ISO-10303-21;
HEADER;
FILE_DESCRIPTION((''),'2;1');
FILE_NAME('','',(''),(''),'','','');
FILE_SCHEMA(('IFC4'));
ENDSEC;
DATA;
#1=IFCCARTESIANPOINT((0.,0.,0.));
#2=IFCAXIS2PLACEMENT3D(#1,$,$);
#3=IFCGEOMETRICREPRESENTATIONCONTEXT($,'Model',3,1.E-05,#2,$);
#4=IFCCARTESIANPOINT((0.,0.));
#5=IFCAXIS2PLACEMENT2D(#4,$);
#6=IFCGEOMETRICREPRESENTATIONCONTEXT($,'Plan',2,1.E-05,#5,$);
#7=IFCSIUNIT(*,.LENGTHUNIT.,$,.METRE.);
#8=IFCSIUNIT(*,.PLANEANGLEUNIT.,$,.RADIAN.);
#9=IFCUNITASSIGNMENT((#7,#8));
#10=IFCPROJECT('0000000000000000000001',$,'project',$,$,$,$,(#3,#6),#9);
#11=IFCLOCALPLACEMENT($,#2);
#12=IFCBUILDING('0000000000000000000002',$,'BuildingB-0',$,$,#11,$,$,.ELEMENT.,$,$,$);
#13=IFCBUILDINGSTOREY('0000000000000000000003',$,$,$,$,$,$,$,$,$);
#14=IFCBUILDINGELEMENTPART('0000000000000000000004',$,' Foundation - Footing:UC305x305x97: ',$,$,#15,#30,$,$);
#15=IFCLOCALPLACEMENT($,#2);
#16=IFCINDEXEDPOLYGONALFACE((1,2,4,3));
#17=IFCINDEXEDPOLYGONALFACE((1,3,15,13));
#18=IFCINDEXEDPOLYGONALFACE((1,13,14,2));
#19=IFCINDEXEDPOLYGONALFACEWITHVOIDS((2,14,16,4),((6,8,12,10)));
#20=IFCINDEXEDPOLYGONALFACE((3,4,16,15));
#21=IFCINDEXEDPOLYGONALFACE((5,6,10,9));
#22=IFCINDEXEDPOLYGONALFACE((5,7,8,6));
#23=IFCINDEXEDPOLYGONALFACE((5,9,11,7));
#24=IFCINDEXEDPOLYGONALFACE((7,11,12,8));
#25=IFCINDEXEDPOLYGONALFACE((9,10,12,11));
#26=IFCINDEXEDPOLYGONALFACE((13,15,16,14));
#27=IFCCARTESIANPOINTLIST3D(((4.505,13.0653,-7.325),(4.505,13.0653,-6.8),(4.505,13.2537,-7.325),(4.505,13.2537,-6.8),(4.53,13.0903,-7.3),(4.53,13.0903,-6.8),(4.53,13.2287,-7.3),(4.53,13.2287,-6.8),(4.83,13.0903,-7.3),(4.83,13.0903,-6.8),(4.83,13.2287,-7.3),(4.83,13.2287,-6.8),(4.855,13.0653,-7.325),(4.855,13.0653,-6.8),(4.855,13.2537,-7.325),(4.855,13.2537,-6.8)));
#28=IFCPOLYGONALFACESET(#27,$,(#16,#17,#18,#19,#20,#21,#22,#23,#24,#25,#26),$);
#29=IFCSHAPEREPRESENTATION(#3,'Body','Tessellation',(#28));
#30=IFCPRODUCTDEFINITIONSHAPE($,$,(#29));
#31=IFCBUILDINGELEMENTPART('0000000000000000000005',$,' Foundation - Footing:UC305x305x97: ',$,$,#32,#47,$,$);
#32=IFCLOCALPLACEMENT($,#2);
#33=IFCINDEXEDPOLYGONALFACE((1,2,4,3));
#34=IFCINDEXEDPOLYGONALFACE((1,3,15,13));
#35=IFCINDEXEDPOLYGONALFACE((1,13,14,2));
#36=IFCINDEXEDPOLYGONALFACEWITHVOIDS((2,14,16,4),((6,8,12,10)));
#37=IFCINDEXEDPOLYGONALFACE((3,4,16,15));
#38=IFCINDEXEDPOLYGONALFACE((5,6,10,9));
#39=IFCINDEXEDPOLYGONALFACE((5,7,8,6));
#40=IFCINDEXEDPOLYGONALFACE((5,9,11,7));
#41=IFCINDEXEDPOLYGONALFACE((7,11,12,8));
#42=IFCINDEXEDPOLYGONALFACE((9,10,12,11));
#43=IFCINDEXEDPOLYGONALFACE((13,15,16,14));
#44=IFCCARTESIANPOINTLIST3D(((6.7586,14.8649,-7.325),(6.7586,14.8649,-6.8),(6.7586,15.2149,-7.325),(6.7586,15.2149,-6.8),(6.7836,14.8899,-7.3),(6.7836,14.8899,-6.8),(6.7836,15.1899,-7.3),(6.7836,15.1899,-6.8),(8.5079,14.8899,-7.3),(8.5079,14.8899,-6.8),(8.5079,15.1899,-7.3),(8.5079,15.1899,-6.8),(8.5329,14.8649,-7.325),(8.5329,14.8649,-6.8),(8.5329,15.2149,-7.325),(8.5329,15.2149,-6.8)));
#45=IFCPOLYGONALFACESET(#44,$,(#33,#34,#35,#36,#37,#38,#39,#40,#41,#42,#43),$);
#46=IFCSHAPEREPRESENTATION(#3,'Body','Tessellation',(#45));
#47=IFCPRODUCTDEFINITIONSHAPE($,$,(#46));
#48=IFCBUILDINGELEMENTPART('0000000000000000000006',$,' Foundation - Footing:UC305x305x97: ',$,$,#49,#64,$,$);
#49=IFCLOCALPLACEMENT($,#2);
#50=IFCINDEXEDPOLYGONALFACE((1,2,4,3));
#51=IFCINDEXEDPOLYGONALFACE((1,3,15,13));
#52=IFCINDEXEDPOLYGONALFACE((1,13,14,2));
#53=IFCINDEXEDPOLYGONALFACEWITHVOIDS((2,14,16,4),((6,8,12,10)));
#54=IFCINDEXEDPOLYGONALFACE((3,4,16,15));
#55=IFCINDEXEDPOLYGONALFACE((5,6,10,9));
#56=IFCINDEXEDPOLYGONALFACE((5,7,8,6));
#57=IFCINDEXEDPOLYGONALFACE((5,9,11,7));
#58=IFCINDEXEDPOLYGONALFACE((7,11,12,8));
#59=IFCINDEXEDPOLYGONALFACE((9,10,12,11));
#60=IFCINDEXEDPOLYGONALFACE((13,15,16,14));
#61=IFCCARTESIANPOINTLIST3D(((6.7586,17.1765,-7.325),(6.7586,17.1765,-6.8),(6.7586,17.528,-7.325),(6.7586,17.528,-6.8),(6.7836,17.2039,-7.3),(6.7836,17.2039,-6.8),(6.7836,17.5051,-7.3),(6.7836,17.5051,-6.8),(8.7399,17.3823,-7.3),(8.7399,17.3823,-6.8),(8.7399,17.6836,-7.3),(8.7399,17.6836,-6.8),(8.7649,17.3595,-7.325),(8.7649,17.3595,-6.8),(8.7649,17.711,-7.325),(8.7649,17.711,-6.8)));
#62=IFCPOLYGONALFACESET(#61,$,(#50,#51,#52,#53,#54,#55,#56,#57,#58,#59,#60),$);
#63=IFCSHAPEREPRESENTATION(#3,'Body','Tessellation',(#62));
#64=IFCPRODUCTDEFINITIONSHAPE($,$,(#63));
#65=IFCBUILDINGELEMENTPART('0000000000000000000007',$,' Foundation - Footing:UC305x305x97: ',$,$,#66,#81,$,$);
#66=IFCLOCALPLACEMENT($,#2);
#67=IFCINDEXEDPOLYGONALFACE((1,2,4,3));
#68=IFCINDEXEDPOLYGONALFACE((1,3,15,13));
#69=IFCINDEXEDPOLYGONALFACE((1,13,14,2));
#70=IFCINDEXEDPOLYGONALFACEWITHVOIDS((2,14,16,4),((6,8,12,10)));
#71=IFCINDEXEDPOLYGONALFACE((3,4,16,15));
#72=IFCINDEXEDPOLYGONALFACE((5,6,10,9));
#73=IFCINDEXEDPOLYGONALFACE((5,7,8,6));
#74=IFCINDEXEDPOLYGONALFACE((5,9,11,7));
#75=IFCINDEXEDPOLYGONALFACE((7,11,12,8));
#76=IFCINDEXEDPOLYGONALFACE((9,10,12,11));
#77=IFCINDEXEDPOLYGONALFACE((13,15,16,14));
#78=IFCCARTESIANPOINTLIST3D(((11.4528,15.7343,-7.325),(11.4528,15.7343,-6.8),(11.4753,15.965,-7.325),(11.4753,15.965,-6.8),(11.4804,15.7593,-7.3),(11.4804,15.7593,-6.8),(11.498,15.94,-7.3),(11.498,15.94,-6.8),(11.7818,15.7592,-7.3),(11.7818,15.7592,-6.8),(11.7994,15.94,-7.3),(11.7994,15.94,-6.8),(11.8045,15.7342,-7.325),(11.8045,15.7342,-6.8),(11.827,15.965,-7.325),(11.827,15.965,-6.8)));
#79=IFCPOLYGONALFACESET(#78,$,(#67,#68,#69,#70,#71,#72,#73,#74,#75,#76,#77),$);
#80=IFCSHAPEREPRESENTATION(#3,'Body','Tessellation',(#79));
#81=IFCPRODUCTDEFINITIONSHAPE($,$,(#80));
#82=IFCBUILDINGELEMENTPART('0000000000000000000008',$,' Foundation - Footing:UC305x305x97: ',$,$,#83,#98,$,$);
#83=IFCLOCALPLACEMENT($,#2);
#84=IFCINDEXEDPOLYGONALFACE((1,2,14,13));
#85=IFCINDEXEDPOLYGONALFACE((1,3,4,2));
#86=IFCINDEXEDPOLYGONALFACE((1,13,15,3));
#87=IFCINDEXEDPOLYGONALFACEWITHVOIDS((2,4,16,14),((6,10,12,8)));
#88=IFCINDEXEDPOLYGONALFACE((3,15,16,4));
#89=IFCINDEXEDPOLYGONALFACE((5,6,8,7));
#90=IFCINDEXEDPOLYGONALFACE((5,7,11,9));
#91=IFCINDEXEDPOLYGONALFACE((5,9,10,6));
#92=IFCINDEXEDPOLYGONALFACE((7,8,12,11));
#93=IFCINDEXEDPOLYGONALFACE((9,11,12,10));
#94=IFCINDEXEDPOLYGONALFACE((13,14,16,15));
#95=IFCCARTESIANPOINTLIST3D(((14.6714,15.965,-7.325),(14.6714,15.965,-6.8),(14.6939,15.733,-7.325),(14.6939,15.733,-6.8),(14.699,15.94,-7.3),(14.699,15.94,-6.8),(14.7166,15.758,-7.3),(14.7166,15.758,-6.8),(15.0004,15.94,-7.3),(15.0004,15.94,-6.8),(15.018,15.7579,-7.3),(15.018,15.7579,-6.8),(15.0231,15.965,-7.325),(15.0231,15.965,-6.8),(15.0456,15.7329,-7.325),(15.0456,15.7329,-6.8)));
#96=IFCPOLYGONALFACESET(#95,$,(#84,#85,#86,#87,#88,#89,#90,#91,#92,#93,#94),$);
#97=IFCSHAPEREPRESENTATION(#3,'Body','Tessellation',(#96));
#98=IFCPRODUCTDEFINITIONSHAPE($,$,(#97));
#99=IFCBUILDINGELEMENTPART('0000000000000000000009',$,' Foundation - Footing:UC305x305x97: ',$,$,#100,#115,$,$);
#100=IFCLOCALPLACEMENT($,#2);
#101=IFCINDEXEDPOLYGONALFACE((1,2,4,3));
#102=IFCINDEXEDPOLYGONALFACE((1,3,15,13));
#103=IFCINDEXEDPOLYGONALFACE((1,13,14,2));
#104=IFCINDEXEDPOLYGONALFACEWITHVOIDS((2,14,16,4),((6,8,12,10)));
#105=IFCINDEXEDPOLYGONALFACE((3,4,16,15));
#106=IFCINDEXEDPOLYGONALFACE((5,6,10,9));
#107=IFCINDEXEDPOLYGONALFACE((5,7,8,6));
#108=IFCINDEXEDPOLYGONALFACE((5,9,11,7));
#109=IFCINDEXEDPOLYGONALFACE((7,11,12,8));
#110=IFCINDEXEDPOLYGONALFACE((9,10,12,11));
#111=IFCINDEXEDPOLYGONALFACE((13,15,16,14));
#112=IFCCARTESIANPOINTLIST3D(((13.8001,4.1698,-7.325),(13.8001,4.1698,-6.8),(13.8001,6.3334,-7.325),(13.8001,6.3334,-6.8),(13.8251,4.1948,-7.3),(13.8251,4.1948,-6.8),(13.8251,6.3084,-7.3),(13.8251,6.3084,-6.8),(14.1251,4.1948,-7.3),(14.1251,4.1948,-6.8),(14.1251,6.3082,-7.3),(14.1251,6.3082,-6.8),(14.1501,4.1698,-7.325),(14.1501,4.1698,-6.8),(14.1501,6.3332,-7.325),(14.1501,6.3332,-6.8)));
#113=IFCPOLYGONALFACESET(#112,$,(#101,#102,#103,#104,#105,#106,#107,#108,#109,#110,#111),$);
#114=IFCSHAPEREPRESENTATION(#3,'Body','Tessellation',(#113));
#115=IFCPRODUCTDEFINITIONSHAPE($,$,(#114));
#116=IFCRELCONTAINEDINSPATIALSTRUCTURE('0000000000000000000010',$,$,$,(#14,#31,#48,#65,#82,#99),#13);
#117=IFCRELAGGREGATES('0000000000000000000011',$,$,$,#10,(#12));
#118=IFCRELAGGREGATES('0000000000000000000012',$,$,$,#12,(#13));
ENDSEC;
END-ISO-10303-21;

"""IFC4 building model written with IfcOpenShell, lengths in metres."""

from ifc_helpers import new_model, si_unit, origin, origin_2d, place, context, project, spatial, polyline, outline, extrude, element, save


model = new_model("IFC4")

# Units and contexts
model_context = context("Model", 3, precision=1e-05, world=origin())
plan_context = context("Plan", 2, precision=1e-05, world=origin_2d())
ifc_project = project(units=[si_unit("LENGTHUNIT", "METRE"), si_unit("PLANEANGLEUNIT", "RADIAN")], contexts=[model_context, plan_context])

# Building, storey
building_placement = place(None, origin())
building = spatial("IfcBuilding", under=ifc_project, at=building_placement, Name="BuildingB-0", CompositionType="ELEMENT")
storey = spatial("IfcBuildingStorey", under=building)

# Building element parts, openings
building_element_part_1 = element("IfcBuildingElementPart", 1, inside=storey, Name=" Foundation - Footing:UC305x305x97: ", context=model_context, shape_type="SweptSolid", body=[
    extrude(outline(polyline([(4.505, 13.0653, -7.325), (4.505, 13.2537, -7.325), (4.855, 13.2537, -7.325), (4.855, 13.0653, -7.325), (4.505, 13.0653, -7.325)])), None, (0.0, 0.0, 1.0), 0.525),
])
element("IfcOpeningElement", 2, inside=storey, cuts=building_element_part_1, context=model_context, shape_type="SweptSolid", body=[
    extrude(outline(polyline([(4.53, 13.0903, -7.3), (4.53, 13.2287, -7.3), (4.83, 13.2287, -7.3), (4.83, 13.0903, -7.3), (4.53, 13.0903, -7.3)])), None, (0.0, 0.0, 1.0), 0.5),
])
building_element_part_2 = element("IfcBuildingElementPart", 3, inside=storey, Name=" Foundation - Footing:UC305x305x97: ", context=model_context, shape_type="SweptSolid", body=[
    extrude(outline(polyline([(6.7586, 14.8649, -7.325), (6.7586, 15.2149, -7.325), (8.5329, 15.2149, -7.325), (8.5329, 14.8649, -7.325), (6.7586, 14.8649, -7.325)])), None, (0.0, 0.0, 1.0), 0.525),
])
element("IfcOpeningElement", 4, inside=storey, cuts=building_element_part_2, context=model_context, shape_type="SweptSolid", body=[
    extrude(outline(polyline([(6.7836, 14.8899, -7.3), (6.7836, 15.1899, -7.3), (8.5079, 15.1899, -7.3), (8.5079, 14.8899, -7.3), (6.7836, 14.8899, -7.3)])), None, (0.0, 0.0, 1.0), 0.5),
])
building_element_part_3 = element("IfcBuildingElementPart", 5, inside=storey, Name=" Foundation - Footing:UC305x305x97: ", context=model_context, shape_type="SweptSolid", body=[
    extrude(outline(polyline([(6.7586, 17.1765, -7.325), (6.7586, 17.528, -7.325), (8.7649, 17.711, -7.325), (8.7649, 17.3595, -7.325), (6.7586, 17.1765, -7.325)])), None, (0.0, 0.0, 1.0), 0.525),
])
element("IfcOpeningElement", 6, inside=storey, cuts=building_element_part_3, context=model_context, shape_type="SweptSolid", body=[
    extrude(outline(polyline([(6.7836, 17.2039, -7.3), (6.7836, 17.5051, -7.3), (8.7399, 17.6836, -7.3), (8.7399, 17.3823, -7.3), (6.7836, 17.2039, -7.3)])), None, (0.0, 0.0, 1.0), 0.5),
])
building_element_part_4 = element("IfcBuildingElementPart", 7, inside=storey, Name=" Foundation - Footing:UC305x305x97: ", context=model_context, shape_type="SweptSolid", body=[
    extrude(outline(polyline([(11.4528, 15.7343, -7.325), (11.4753, 15.965, -7.325), (11.827, 15.965, -7.325), (11.8045, 15.7342, -7.325), (11.4528, 15.7343, -7.325)])), None, (0.0, 0.0, 1.0), 0.525),
])
element("IfcOpeningElement", 8, inside=storey, cuts=building_element_part_4, context=model_context, shape_type="SweptSolid", body=[
    extrude(outline(polyline([(11.4804, 15.7593, -7.3), (11.498, 15.94, -7.3), (11.7994, 15.94, -7.3), (11.7818, 15.7592, -7.3), (11.4804, 15.7593, -7.3)])), None, (0.0, 0.0, 1.0), 0.5),
])
building_element_part_5 = element("IfcBuildingElementPart", 9, inside=storey, Name=" Foundation - Footing:UC305x305x97: ", context=model_context, shape_type="SweptSolid", body=[
    extrude(outline(polyline([(14.6939, 15.733, -7.325), (14.6714, 15.965, -7.325), (15.0231, 15.965, -7.325), (15.0456, 15.7329, -7.325), (14.6939, 15.733, -7.325)])), None, (0.0, 0.0, 1.0), 0.525),
])
element("IfcOpeningElement", 10, inside=storey, cuts=building_element_part_5, context=model_context, shape_type="SweptSolid", body=[
    extrude(outline(polyline([(14.7166, 15.758, -7.3), (14.699, 15.94, -7.3), (15.0004, 15.94, -7.3), (15.018, 15.7579, -7.3), (14.7166, 15.758, -7.3)])), None, (0.0, 0.0, 1.0), 0.5),
])
building_element_part_6 = element("IfcBuildingElementPart", 11, inside=storey, Name=" Foundation - Footing:UC305x305x97: ", context=model_context, shape_type="SweptSolid", body=[
    extrude(outline(polyline([(13.8001, 4.1698, -7.325), (13.8001, 6.3334, -7.325), (14.1501, 6.3332, -7.325), (14.1501, 4.1698, -7.325), (13.8001, 4.1698, -7.325)])), None, (0.0, 0.0, 1.0), 0.525),
])
element("IfcOpeningElement", 12, inside=storey, cuts=building_element_part_6, context=model_context, shape_type="SweptSolid", body=[
    extrude(outline(polyline([(13.8251, 4.1948, -7.3), (13.8251, 6.3084, -7.3), (14.1251, 6.3082, -7.3), (14.1251, 4.1948, -7.3), (13.8251, 4.1948, -7.3)])), None, (0.0, 0.0, 1.0), 0.5),
])

save(model, "model.ifc")
